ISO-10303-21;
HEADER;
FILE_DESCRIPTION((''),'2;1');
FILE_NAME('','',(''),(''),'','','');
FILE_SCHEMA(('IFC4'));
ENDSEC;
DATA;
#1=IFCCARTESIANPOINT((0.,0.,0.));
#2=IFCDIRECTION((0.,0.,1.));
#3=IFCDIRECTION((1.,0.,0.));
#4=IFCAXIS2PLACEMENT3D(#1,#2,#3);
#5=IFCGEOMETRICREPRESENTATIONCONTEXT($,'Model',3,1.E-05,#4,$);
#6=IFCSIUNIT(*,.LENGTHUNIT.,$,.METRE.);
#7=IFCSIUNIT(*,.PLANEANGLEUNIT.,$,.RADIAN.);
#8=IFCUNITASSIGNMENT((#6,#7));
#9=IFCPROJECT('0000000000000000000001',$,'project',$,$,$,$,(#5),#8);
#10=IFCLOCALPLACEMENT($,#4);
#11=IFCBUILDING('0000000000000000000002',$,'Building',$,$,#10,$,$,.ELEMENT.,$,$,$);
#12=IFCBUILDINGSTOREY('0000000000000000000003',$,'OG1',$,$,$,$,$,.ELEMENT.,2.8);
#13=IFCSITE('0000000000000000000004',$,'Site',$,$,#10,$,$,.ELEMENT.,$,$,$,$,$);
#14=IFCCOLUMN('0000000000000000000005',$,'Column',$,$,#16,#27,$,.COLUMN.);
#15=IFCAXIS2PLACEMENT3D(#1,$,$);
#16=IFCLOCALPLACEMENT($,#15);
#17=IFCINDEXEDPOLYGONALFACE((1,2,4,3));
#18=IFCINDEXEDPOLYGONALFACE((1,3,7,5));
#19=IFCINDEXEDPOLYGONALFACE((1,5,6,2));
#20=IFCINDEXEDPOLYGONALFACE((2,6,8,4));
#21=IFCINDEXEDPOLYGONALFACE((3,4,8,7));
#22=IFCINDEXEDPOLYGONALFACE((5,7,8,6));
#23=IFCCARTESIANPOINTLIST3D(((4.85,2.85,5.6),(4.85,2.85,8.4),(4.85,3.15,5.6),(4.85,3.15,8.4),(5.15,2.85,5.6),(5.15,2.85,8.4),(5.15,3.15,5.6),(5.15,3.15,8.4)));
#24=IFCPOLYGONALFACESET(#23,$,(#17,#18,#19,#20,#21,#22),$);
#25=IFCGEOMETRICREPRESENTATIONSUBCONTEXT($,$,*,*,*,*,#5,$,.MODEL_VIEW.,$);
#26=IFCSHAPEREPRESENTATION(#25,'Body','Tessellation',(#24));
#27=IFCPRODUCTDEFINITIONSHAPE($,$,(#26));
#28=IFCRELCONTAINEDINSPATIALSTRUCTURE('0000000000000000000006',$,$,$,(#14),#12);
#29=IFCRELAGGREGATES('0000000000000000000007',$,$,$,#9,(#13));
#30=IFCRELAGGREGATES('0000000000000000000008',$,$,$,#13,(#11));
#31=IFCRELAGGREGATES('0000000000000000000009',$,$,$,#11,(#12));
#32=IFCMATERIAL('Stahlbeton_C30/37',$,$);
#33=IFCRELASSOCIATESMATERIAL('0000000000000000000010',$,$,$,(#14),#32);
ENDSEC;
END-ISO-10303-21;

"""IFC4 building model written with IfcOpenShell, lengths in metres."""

from ifc_helpers import new_model, si_unit, frame, origin, origin_with_axes, origin_2d, place, context, subcontext, project, spatial, rectangle, extrude, material, element, save


model = new_model("IFC4")

# Units and contexts
model_context = context("Model", 3, precision=1e-05, world=origin_with_axes())
sub_context = subcontext(model_context, None, None, "MODEL_VIEW")
ifc_project = project(units=[si_unit("LENGTHUNIT", "METRE"), si_unit("PLANEANGLEUNIT", "RADIAN")], contexts=[model_context])

# Site, building, storey
placement_1 = place(None, origin_with_axes())
site = spatial("IfcSite", under=ifc_project, at=placement_1, Name="Site", CompositionType="ELEMENT")
building = spatial("IfcBuilding", under=site, at=placement_1, Name="Building", CompositionType="ELEMENT")
storey = spatial("IfcBuildingStorey", under=building, Name="OG1", CompositionType="ELEMENT", Elevation=2.8)

# Column
ifc_material = material(Name="Stahlbeton_C30/37")
placement_2 = place(None, origin_with_axes())
placement_3 = place(placement_2, frame((0.0, 0.0, 2.8)))
column_placement = place(placement_3, frame((5.0, 3.0, 2.8)))
element("IfcColumn", 1, at=column_placement, inside=storey, material=ifc_material, Name="Column", PredefinedType="COLUMN", context=sub_context, shape_type="SweptSolid", body=[
    extrude(rectangle(XDim=0.3, YDim=0.3, at=origin_2d()), origin(), (0.0, 0.0, 1.0), 2.8),
])

save(model, "model.ifc")
